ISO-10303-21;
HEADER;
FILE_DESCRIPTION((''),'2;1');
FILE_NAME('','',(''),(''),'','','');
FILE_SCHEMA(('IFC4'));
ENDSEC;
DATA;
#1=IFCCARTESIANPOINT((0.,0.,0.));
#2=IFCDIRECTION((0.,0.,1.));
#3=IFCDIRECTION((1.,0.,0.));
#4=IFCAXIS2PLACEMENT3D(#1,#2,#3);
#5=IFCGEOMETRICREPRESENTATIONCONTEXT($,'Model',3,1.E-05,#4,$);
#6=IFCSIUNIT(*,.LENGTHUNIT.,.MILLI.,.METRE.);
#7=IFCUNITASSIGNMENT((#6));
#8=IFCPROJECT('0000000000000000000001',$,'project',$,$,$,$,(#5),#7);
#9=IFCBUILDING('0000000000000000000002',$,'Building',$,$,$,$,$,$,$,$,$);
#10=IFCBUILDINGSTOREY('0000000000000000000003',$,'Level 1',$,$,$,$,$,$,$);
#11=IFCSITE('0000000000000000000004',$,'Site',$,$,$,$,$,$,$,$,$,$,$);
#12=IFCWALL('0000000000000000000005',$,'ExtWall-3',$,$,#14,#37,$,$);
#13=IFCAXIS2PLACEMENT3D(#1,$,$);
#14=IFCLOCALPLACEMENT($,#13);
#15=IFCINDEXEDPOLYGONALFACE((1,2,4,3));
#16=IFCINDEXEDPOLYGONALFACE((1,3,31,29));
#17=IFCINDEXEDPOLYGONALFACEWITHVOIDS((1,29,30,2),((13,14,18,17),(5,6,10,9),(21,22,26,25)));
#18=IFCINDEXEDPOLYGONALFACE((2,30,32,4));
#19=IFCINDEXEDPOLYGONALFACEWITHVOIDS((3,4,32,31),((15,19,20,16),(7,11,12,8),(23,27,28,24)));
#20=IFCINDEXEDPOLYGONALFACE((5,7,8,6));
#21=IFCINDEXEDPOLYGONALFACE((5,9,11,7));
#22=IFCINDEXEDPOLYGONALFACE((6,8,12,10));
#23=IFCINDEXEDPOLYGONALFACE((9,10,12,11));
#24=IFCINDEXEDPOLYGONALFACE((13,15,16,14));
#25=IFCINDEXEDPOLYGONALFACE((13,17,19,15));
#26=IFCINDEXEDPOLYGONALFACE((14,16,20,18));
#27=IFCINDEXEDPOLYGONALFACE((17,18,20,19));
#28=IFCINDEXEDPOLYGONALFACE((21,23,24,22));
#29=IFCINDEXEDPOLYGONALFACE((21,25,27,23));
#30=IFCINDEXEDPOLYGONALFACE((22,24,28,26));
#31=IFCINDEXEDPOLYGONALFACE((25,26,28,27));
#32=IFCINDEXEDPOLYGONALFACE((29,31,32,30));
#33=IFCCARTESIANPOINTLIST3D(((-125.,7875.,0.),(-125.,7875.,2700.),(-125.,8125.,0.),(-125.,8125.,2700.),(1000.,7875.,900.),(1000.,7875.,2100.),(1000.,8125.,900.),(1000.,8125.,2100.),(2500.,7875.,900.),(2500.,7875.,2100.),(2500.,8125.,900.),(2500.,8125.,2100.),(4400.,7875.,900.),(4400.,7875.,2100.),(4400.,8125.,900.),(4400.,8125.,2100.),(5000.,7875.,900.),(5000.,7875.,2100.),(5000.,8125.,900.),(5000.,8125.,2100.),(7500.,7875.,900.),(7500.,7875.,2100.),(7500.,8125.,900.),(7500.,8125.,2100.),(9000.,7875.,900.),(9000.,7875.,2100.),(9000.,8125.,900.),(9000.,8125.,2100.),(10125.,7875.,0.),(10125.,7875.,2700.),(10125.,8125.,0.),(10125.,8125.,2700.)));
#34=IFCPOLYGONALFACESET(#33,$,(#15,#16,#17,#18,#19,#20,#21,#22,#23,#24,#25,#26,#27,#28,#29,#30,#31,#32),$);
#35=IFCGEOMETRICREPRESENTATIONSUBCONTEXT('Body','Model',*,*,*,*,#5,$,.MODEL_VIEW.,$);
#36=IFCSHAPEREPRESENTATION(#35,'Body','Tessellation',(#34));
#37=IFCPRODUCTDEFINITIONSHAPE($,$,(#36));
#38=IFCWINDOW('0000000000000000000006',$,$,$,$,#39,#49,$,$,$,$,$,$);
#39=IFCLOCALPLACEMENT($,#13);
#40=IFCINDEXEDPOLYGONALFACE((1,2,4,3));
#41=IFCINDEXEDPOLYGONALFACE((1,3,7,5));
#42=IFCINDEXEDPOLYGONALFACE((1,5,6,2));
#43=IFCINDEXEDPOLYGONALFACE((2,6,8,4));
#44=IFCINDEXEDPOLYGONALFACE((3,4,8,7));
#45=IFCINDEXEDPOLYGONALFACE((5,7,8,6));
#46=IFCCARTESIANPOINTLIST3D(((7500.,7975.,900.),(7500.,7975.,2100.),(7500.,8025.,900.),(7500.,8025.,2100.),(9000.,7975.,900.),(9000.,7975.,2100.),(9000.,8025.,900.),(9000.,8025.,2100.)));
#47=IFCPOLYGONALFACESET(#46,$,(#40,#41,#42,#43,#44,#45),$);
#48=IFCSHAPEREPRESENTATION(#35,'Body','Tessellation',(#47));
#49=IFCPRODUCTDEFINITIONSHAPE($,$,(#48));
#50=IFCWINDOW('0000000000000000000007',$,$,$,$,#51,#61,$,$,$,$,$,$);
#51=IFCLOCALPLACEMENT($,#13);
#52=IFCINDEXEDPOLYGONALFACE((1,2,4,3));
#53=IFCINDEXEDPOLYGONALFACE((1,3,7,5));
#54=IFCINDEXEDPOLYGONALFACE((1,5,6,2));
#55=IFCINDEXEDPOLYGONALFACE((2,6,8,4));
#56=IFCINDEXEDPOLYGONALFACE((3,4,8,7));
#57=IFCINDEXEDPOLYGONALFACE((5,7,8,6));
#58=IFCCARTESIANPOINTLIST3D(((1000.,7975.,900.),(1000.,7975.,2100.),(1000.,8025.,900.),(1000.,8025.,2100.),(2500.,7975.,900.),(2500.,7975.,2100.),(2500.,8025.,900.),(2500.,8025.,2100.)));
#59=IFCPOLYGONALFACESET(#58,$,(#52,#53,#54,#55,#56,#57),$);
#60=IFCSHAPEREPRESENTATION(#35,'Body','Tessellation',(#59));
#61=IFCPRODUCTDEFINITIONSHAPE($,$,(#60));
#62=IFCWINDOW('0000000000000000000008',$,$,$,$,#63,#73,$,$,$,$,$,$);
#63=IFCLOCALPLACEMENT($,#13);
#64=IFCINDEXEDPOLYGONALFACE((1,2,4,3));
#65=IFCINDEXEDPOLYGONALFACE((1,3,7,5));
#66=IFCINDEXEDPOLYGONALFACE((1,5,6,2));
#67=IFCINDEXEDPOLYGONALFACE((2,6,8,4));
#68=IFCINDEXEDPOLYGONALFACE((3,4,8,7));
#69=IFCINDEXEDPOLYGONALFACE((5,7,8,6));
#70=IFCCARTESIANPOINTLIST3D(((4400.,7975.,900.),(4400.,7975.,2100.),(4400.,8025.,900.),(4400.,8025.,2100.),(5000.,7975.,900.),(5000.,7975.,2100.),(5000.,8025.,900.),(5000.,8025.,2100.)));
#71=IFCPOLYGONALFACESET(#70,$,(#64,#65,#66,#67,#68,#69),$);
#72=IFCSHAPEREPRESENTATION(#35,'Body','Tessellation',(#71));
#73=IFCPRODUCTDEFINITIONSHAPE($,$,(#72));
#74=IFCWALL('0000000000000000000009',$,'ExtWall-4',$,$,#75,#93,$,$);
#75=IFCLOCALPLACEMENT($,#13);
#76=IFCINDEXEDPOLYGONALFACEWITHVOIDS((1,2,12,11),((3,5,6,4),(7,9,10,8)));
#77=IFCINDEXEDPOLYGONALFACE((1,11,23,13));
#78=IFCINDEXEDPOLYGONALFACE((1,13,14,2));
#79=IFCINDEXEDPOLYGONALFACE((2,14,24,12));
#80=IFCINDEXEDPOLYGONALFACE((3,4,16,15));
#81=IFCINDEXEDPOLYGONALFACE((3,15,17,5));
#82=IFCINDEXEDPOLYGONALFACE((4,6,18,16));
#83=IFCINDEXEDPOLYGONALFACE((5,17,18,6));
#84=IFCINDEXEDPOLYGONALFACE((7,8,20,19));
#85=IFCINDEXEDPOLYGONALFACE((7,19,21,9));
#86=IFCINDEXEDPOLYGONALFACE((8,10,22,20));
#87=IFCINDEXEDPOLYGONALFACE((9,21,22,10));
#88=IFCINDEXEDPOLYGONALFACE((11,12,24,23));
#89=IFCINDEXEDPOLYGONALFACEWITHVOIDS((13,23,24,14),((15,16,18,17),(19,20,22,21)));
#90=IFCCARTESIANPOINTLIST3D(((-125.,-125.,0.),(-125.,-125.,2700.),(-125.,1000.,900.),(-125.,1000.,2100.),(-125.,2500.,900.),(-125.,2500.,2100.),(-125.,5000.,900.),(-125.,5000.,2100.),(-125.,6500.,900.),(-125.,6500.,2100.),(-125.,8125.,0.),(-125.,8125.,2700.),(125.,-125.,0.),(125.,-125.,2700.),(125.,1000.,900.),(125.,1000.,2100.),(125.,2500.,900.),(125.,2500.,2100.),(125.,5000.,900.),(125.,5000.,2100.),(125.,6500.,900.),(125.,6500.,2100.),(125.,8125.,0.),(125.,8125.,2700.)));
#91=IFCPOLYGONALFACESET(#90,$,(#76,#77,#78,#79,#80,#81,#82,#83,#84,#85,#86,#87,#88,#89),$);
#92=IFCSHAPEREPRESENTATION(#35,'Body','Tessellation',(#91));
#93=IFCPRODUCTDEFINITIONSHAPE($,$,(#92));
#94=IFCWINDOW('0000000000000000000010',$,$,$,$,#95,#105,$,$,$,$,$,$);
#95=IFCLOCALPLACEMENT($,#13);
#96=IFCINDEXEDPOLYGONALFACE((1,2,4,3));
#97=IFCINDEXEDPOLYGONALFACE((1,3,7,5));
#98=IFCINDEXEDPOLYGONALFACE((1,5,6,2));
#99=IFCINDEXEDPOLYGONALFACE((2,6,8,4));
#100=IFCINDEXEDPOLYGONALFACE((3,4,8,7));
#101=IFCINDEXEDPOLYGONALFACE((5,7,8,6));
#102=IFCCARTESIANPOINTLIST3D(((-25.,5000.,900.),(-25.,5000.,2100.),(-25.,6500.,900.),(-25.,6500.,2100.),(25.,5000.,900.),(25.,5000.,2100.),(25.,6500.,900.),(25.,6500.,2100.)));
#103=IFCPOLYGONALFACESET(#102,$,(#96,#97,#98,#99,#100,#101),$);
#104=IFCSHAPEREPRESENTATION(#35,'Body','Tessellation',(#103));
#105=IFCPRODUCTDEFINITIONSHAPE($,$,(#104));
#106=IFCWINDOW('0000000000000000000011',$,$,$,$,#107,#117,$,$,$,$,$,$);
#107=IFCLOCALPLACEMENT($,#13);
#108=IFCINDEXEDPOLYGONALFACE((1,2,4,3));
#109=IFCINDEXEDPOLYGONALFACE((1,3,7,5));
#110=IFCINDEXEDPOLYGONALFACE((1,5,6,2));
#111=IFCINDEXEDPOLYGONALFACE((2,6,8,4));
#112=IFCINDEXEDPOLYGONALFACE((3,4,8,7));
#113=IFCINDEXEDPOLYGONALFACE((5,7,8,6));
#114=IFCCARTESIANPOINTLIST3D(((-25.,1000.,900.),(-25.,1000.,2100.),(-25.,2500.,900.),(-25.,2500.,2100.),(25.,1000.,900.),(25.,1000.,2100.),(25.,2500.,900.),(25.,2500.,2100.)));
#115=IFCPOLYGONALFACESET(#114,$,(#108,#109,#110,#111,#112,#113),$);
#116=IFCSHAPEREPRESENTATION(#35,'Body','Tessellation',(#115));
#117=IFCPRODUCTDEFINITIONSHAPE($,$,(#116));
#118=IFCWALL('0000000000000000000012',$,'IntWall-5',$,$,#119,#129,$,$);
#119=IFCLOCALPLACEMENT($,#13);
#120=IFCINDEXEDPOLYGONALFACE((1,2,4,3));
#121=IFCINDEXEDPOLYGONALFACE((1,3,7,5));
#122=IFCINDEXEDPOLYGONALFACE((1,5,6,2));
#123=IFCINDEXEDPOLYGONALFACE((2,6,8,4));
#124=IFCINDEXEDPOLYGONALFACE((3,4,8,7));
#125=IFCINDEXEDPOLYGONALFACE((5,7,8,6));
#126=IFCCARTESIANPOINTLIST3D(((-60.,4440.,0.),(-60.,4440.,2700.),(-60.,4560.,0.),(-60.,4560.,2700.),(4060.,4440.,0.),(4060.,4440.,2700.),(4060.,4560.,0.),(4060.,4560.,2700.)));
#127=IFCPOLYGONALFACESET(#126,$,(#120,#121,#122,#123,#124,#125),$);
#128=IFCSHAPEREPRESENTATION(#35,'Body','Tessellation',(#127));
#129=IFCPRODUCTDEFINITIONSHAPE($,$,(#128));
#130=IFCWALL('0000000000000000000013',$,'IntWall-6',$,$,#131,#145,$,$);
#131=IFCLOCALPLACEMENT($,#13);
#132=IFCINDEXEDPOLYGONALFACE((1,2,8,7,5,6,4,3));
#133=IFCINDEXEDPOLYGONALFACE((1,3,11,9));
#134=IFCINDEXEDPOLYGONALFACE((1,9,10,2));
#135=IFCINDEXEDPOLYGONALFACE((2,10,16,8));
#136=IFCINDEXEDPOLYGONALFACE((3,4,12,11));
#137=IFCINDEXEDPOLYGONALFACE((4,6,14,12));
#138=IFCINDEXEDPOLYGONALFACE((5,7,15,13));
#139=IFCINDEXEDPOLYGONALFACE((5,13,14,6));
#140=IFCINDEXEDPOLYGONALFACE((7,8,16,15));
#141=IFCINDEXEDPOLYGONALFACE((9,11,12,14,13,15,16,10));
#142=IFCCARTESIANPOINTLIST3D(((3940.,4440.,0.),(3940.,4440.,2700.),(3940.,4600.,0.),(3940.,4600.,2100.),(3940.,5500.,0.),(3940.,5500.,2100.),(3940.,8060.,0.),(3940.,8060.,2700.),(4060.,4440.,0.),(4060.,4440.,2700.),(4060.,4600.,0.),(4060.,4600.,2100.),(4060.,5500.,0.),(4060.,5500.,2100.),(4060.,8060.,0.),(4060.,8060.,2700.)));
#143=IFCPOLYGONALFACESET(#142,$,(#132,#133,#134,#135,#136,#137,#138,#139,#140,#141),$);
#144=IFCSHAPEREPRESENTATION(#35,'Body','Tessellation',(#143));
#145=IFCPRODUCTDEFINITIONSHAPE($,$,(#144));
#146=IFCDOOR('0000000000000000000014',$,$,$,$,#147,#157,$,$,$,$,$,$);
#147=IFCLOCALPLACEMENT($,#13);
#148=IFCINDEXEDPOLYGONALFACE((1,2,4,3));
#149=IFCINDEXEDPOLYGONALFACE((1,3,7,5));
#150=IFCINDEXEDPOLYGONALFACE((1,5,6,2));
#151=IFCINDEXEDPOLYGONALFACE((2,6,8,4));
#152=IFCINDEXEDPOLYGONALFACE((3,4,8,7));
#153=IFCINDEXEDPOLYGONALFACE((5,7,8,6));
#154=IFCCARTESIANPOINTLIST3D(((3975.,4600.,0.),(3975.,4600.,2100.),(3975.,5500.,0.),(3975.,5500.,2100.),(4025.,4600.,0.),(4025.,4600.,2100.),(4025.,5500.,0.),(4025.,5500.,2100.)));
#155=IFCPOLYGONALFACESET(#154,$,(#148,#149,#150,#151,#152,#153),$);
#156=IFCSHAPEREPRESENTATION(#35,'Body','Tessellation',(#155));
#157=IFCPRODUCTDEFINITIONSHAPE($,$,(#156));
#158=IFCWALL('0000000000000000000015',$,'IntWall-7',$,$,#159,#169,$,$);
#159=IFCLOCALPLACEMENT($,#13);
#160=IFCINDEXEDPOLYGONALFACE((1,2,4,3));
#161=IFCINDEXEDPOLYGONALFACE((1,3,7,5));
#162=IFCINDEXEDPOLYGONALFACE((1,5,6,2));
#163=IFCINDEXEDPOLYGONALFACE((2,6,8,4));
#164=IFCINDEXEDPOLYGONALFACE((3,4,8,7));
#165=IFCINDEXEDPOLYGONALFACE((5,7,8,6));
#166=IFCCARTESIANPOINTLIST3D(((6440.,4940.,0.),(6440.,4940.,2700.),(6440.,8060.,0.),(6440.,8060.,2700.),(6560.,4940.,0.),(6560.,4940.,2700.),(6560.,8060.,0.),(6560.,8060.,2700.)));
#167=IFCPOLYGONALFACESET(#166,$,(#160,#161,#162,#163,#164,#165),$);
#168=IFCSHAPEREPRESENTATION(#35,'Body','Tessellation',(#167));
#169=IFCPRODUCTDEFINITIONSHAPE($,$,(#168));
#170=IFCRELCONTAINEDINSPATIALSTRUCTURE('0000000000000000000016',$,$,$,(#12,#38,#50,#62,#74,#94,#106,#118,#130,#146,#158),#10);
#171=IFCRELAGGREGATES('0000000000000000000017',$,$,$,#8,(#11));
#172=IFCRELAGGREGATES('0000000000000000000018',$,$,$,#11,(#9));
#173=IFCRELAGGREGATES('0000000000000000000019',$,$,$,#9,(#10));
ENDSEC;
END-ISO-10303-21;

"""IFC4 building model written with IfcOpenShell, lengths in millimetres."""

from ifc_helpers import new_model, si_unit, frame, origin_with_axes, place, context, subcontext, project, spatial, indexed_curve, outline, extrude, element, fill, save


model = new_model("IFC4")

# Units and contexts
model_context = context("Model", 3, precision=1e-05, world=origin_with_axes())
body_context = subcontext(model_context, "Body", "Model", "MODEL_VIEW")
ifc_project = project(units=[si_unit("LENGTHUNIT", "METRE", prefix="MILLI")], contexts=[model_context])

# Site, building, storey
site = spatial("IfcSite", under=ifc_project, Name="Site")
building = spatial("IfcBuilding", under=site, Name="Building")
storey = spatial("IfcBuildingStorey", under=building, Name="Level 1")

# Walls, openings, windows
wall_1_placement = place(None, frame((-125.0, 8000.0, 0.0), z_axis=(0.0, 0.0, 1.0), x_axis=(1.0, 0.0, 0.0)))
wall_1 = element("IfcWall", 1, at=wall_1_placement, inside=storey, Name="ExtWall-3", context=body_context, shape_type="SweptSolid", body=[
    extrude(outline(indexed_curve([(0.0, 0.0), (0.0, 250.0), (10250.0, 250.0), (10250.0, 0.0), (0.0, 0.0)], self_intersect=False)), frame((0.0, -125.0, 0.0), z_axis=(0.0, 0.0, 1.0), x_axis=(1.0, 0.0, 0.0)), (0.0, 0.0, 1.0), 2700.0),
])
opening_1_placement = place(wall_1_placement, frame((7625.0, 0.0, 900.0), z_axis=(0.0, 0.0, 1.0), x_axis=(1.0, 0.0, 0.0)))
opening_1 = element("IfcOpeningElement", 2, at=opening_1_placement, cuts=wall_1, context=body_context, shape_type="SweptSolid", body=[
    extrude(outline(indexed_curve([(0.0, 0.0), (0.0, 350.0), (1500.0, 350.0), (1500.0, 0.0), (0.0, 0.0)], self_intersect=False)), frame((0.0, -175.0, 0.0), z_axis=(0.0, 0.0, 1.0), x_axis=(1.0, 0.0, 0.0)), (0.0, 0.0, 1.0), 1200.0),
])
opening_2_placement = place(wall_1_placement, frame((1125.0, 0.0, 900.0), z_axis=(0.0, 0.0, 1.0), x_axis=(1.0, 0.0, 0.0)))
opening_2 = element("IfcOpeningElement", 3, at=opening_2_placement, cuts=wall_1, context=body_context, shape_type="SweptSolid", body=[
    extrude(outline(indexed_curve([(0.0, 0.0), (0.0, 350.0), (1500.0, 350.0), (1500.0, 0.0), (0.0, 0.0)], self_intersect=False)), frame((0.0, -175.0, 0.0), z_axis=(0.0, 0.0, 1.0), x_axis=(1.0, 0.0, 0.0)), (0.0, 0.0, 1.0), 1200.0),
])
opening_3_placement = place(wall_1_placement, frame((4525.0, 0.0, 900.0), z_axis=(0.0, 0.0, 1.0), x_axis=(1.0, 0.0, 0.0)))
opening_3 = element("IfcOpeningElement", 4, at=opening_3_placement, cuts=wall_1, context=body_context, shape_type="SweptSolid", body=[
    extrude(outline(indexed_curve([(0.0, 0.0), (0.0, 350.0), (600.0, 350.0), (600.0, 0.0), (0.0, 0.0)], self_intersect=False)), frame((0.0, -175.0, 0.0), z_axis=(0.0, 0.0, 1.0), x_axis=(1.0, 0.0, 0.0)), (0.0, 0.0, 1.0), 1200.0),
])
window_1_placement = place(opening_1_placement, origin_with_axes())
window_1 = element("IfcWindow", 5, at=window_1_placement, inside=storey, context=body_context, shape_type="SweptSolid", body=[
    extrude(outline(indexed_curve([(0.0, 0.0), (0.0, 50.0), (1500.0, 50.0), (1500.0, 0.0), (0.0, 0.0)], self_intersect=False)), frame((0.0, -25.0, 0.0), z_axis=(0.0, 0.0, 1.0), x_axis=(1.0, 0.0, 0.0)), (0.0, 0.0, 1.0), 1200.0),
])
fill(opening_1, window_1)
window_2_placement = place(opening_2_placement, origin_with_axes())
window_2 = element("IfcWindow", 6, at=window_2_placement, inside=storey, context=body_context, shape_type="SweptSolid", body=[
    extrude(outline(indexed_curve([(0.0, 0.0), (0.0, 50.0), (1500.0, 50.0), (1500.0, 0.0), (0.0, 0.0)], self_intersect=False)), frame((0.0, -25.0, 0.0), z_axis=(0.0, 0.0, 1.0), x_axis=(1.0, 0.0, 0.0)), (0.0, 0.0, 1.0), 1200.0),
])
fill(opening_2, window_2)
window_3_placement = place(opening_3_placement, origin_with_axes())
window_3 = element("IfcWindow", 7, at=window_3_placement, inside=storey, context=body_context, shape_type="SweptSolid", body=[
    extrude(outline(indexed_curve([(0.0, 0.0), (0.0, 50.0), (600.0, 50.0), (600.0, 0.0), (0.0, 0.0)], self_intersect=False)), frame((0.0, -25.0, 0.0), z_axis=(0.0, 0.0, 1.0), x_axis=(1.0, 0.0, 0.0)), (0.0, 0.0, 1.0), 1200.0),
])
fill(opening_3, window_3)
wall_2_placement = place(None, frame((0.0, -125.0, 0.0), z_axis=(0.0, 0.0, 1.0), x_axis=(0.0, 1.0, 0.0)))
wall_2 = element("IfcWall", 8, at=wall_2_placement, inside=storey, Name="ExtWall-4", context=body_context, shape_type="SweptSolid", body=[
    extrude(outline(indexed_curve([(0.0, 0.0), (0.0, 250.0), (8250.0, 250.0), (8250.0, 0.0), (0.0, 0.0)], self_intersect=False)), frame((0.0, -125.0, 0.0), z_axis=(0.0, 0.0, 1.0), x_axis=(1.0, 0.0, 0.0)), (0.0, 0.0, 1.0), 2700.0),
])
opening_4_placement = place(wall_2_placement, frame((5125.0, 0.0, 900.0), z_axis=(0.0, 0.0, 1.0), x_axis=(1.0, 0.0, 0.0)))
opening_4 = element("IfcOpeningElement", 9, at=opening_4_placement, cuts=wall_2, context=body_context, shape_type="SweptSolid", body=[
    extrude(outline(indexed_curve([(0.0, 0.0), (0.0, 350.0), (1500.0, 350.0), (1500.0, 0.0), (0.0, 0.0)], self_intersect=False)), frame((0.0, -175.0, 0.0), z_axis=(0.0, 0.0, 1.0), x_axis=(1.0, 0.0, 0.0)), (0.0, 0.0, 1.0), 1200.0),
])
opening_5_placement = place(wall_2_placement, frame((1125.0, 0.0, 900.0), z_axis=(0.0, 0.0, 1.0), x_axis=(1.0, 0.0, 0.0)))
opening_5 = element("IfcOpeningElement", 10, at=opening_5_placement, cuts=wall_2, context=body_context, shape_type="SweptSolid", body=[
    extrude(outline(indexed_curve([(0.0, 0.0), (0.0, 350.0), (1500.0, 350.0), (1500.0, 0.0), (0.0, 0.0)], self_intersect=False)), frame((0.0, -175.0, 0.0), z_axis=(0.0, 0.0, 1.0), x_axis=(1.0, 0.0, 0.0)), (0.0, 0.0, 1.0), 1200.0),
])
window_4_placement = place(opening_4_placement, origin_with_axes())
window_4 = element("IfcWindow", 11, at=window_4_placement, inside=storey, context=body_context, shape_type="SweptSolid", body=[
    extrude(outline(indexed_curve([(0.0, 0.0), (0.0, 50.0), (1500.0, 50.0), (1500.0, 0.0), (0.0, 0.0)], self_intersect=False)), frame((0.0, -25.0, 0.0), z_axis=(0.0, 0.0, 1.0), x_axis=(1.0, 0.0, 0.0)), (0.0, 0.0, 1.0), 1200.0),
])
fill(opening_4, window_4)
window_5_placement = place(opening_5_placement, origin_with_axes())
window_5 = element("IfcWindow", 12, at=window_5_placement, inside=storey, context=body_context, shape_type="SweptSolid", body=[
    extrude(outline(indexed_curve([(0.0, 0.0), (0.0, 50.0), (1500.0, 50.0), (1500.0, 0.0), (0.0, 0.0)], self_intersect=False)), frame((0.0, -25.0, 0.0), z_axis=(0.0, 0.0, 1.0), x_axis=(1.0, 0.0, 0.0)), (0.0, 0.0, 1.0), 1200.0),
])
fill(opening_5, window_5)

# Wall
wall_3_placement = place(None, frame((-60.0, 4500.0, 0.0), z_axis=(0.0, 0.0, 1.0), x_axis=(1.0, 0.0, 0.0)))
element("IfcWall", 13, at=wall_3_placement, inside=storey, Name="IntWall-5", context=body_context, shape_type="SweptSolid", body=[
    extrude(outline(indexed_curve([(0.0, 0.0), (0.0, 120.0), (4120.0, 120.0), (4120.0, 0.0), (0.0, 0.0)], self_intersect=False)), frame((0.0, -60.0, 0.0), z_axis=(0.0, 0.0, 1.0), x_axis=(1.0, 0.0, 0.0)), (0.0, 0.0, 1.0), 2700.0),
])

# Wall, opening, door
wall_4_placement = place(None, frame((4000.0, 4440.0, 0.0), z_axis=(0.0, 0.0, 1.0), x_axis=(0.0, 1.0, 0.0)))
wall_4 = element("IfcWall", 14, at=wall_4_placement, inside=storey, Name="IntWall-6", context=body_context, shape_type="SweptSolid", body=[
    extrude(outline(indexed_curve([(0.0, 0.0), (0.0, 120.0), (3620.0, 120.0), (3620.0, 0.0), (0.0, 0.0)], self_intersect=False)), frame((0.0, -60.0, 0.0), z_axis=(0.0, 0.0, 1.0), x_axis=(1.0, 0.0, 0.0)), (0.0, 0.0, 1.0), 2700.0),
])
opening_6_placement = place(wall_4_placement, frame((160.0, 0.0, 0.0), z_axis=(0.0, 0.0, 1.0), x_axis=(1.0, 0.0, 0.0)))
opening_6 = element("IfcOpeningElement", 15, at=opening_6_placement, cuts=wall_4, context=body_context, shape_type="SweptSolid", body=[
    extrude(outline(indexed_curve([(0.0, 0.0), (0.0, 220.0), (900.0, 220.0), (900.0, 0.0), (0.0, 0.0)], self_intersect=False)), frame((0.0, -110.0, 0.0), z_axis=(0.0, 0.0, 1.0), x_axis=(1.0, 0.0, 0.0)), (0.0, 0.0, 1.0), 2100.0),
])
door_1_placement = place(opening_6_placement, origin_with_axes())
door_1 = element("IfcDoor", 16, at=door_1_placement, inside=storey, context=body_context, shape_type="SweptSolid", body=[
    extrude(outline(indexed_curve([(0.0, 0.0), (0.0, 50.0), (900.0, 50.0), (900.0, 0.0), (0.0, 0.0)], self_intersect=False)), frame((0.0, -25.0, 0.0), z_axis=(0.0, 0.0, 1.0), x_axis=(1.0, 0.0, 0.0)), (0.0, 0.0, 1.0), 2100.0),
])
fill(opening_6, door_1)

# Wall
wall_5_placement = place(None, frame((6500.0, 4940.0, 0.0), z_axis=(0.0, 0.0, 1.0), x_axis=(0.0, 1.0, 0.0)))
element("IfcWall", 17, at=wall_5_placement, inside=storey, Name="IntWall-7", context=body_context, shape_type="SweptSolid", body=[
    extrude(outline(indexed_curve([(0.0, 0.0), (0.0, 120.0), (3120.0, 120.0), (3120.0, 0.0), (0.0, 0.0)], self_intersect=False)), frame((0.0, -60.0, 0.0), z_axis=(0.0, 0.0, 1.0), x_axis=(1.0, 0.0, 0.0)), (0.0, 0.0, 1.0), 2700.0),
])

save(model, "model.ifc")
